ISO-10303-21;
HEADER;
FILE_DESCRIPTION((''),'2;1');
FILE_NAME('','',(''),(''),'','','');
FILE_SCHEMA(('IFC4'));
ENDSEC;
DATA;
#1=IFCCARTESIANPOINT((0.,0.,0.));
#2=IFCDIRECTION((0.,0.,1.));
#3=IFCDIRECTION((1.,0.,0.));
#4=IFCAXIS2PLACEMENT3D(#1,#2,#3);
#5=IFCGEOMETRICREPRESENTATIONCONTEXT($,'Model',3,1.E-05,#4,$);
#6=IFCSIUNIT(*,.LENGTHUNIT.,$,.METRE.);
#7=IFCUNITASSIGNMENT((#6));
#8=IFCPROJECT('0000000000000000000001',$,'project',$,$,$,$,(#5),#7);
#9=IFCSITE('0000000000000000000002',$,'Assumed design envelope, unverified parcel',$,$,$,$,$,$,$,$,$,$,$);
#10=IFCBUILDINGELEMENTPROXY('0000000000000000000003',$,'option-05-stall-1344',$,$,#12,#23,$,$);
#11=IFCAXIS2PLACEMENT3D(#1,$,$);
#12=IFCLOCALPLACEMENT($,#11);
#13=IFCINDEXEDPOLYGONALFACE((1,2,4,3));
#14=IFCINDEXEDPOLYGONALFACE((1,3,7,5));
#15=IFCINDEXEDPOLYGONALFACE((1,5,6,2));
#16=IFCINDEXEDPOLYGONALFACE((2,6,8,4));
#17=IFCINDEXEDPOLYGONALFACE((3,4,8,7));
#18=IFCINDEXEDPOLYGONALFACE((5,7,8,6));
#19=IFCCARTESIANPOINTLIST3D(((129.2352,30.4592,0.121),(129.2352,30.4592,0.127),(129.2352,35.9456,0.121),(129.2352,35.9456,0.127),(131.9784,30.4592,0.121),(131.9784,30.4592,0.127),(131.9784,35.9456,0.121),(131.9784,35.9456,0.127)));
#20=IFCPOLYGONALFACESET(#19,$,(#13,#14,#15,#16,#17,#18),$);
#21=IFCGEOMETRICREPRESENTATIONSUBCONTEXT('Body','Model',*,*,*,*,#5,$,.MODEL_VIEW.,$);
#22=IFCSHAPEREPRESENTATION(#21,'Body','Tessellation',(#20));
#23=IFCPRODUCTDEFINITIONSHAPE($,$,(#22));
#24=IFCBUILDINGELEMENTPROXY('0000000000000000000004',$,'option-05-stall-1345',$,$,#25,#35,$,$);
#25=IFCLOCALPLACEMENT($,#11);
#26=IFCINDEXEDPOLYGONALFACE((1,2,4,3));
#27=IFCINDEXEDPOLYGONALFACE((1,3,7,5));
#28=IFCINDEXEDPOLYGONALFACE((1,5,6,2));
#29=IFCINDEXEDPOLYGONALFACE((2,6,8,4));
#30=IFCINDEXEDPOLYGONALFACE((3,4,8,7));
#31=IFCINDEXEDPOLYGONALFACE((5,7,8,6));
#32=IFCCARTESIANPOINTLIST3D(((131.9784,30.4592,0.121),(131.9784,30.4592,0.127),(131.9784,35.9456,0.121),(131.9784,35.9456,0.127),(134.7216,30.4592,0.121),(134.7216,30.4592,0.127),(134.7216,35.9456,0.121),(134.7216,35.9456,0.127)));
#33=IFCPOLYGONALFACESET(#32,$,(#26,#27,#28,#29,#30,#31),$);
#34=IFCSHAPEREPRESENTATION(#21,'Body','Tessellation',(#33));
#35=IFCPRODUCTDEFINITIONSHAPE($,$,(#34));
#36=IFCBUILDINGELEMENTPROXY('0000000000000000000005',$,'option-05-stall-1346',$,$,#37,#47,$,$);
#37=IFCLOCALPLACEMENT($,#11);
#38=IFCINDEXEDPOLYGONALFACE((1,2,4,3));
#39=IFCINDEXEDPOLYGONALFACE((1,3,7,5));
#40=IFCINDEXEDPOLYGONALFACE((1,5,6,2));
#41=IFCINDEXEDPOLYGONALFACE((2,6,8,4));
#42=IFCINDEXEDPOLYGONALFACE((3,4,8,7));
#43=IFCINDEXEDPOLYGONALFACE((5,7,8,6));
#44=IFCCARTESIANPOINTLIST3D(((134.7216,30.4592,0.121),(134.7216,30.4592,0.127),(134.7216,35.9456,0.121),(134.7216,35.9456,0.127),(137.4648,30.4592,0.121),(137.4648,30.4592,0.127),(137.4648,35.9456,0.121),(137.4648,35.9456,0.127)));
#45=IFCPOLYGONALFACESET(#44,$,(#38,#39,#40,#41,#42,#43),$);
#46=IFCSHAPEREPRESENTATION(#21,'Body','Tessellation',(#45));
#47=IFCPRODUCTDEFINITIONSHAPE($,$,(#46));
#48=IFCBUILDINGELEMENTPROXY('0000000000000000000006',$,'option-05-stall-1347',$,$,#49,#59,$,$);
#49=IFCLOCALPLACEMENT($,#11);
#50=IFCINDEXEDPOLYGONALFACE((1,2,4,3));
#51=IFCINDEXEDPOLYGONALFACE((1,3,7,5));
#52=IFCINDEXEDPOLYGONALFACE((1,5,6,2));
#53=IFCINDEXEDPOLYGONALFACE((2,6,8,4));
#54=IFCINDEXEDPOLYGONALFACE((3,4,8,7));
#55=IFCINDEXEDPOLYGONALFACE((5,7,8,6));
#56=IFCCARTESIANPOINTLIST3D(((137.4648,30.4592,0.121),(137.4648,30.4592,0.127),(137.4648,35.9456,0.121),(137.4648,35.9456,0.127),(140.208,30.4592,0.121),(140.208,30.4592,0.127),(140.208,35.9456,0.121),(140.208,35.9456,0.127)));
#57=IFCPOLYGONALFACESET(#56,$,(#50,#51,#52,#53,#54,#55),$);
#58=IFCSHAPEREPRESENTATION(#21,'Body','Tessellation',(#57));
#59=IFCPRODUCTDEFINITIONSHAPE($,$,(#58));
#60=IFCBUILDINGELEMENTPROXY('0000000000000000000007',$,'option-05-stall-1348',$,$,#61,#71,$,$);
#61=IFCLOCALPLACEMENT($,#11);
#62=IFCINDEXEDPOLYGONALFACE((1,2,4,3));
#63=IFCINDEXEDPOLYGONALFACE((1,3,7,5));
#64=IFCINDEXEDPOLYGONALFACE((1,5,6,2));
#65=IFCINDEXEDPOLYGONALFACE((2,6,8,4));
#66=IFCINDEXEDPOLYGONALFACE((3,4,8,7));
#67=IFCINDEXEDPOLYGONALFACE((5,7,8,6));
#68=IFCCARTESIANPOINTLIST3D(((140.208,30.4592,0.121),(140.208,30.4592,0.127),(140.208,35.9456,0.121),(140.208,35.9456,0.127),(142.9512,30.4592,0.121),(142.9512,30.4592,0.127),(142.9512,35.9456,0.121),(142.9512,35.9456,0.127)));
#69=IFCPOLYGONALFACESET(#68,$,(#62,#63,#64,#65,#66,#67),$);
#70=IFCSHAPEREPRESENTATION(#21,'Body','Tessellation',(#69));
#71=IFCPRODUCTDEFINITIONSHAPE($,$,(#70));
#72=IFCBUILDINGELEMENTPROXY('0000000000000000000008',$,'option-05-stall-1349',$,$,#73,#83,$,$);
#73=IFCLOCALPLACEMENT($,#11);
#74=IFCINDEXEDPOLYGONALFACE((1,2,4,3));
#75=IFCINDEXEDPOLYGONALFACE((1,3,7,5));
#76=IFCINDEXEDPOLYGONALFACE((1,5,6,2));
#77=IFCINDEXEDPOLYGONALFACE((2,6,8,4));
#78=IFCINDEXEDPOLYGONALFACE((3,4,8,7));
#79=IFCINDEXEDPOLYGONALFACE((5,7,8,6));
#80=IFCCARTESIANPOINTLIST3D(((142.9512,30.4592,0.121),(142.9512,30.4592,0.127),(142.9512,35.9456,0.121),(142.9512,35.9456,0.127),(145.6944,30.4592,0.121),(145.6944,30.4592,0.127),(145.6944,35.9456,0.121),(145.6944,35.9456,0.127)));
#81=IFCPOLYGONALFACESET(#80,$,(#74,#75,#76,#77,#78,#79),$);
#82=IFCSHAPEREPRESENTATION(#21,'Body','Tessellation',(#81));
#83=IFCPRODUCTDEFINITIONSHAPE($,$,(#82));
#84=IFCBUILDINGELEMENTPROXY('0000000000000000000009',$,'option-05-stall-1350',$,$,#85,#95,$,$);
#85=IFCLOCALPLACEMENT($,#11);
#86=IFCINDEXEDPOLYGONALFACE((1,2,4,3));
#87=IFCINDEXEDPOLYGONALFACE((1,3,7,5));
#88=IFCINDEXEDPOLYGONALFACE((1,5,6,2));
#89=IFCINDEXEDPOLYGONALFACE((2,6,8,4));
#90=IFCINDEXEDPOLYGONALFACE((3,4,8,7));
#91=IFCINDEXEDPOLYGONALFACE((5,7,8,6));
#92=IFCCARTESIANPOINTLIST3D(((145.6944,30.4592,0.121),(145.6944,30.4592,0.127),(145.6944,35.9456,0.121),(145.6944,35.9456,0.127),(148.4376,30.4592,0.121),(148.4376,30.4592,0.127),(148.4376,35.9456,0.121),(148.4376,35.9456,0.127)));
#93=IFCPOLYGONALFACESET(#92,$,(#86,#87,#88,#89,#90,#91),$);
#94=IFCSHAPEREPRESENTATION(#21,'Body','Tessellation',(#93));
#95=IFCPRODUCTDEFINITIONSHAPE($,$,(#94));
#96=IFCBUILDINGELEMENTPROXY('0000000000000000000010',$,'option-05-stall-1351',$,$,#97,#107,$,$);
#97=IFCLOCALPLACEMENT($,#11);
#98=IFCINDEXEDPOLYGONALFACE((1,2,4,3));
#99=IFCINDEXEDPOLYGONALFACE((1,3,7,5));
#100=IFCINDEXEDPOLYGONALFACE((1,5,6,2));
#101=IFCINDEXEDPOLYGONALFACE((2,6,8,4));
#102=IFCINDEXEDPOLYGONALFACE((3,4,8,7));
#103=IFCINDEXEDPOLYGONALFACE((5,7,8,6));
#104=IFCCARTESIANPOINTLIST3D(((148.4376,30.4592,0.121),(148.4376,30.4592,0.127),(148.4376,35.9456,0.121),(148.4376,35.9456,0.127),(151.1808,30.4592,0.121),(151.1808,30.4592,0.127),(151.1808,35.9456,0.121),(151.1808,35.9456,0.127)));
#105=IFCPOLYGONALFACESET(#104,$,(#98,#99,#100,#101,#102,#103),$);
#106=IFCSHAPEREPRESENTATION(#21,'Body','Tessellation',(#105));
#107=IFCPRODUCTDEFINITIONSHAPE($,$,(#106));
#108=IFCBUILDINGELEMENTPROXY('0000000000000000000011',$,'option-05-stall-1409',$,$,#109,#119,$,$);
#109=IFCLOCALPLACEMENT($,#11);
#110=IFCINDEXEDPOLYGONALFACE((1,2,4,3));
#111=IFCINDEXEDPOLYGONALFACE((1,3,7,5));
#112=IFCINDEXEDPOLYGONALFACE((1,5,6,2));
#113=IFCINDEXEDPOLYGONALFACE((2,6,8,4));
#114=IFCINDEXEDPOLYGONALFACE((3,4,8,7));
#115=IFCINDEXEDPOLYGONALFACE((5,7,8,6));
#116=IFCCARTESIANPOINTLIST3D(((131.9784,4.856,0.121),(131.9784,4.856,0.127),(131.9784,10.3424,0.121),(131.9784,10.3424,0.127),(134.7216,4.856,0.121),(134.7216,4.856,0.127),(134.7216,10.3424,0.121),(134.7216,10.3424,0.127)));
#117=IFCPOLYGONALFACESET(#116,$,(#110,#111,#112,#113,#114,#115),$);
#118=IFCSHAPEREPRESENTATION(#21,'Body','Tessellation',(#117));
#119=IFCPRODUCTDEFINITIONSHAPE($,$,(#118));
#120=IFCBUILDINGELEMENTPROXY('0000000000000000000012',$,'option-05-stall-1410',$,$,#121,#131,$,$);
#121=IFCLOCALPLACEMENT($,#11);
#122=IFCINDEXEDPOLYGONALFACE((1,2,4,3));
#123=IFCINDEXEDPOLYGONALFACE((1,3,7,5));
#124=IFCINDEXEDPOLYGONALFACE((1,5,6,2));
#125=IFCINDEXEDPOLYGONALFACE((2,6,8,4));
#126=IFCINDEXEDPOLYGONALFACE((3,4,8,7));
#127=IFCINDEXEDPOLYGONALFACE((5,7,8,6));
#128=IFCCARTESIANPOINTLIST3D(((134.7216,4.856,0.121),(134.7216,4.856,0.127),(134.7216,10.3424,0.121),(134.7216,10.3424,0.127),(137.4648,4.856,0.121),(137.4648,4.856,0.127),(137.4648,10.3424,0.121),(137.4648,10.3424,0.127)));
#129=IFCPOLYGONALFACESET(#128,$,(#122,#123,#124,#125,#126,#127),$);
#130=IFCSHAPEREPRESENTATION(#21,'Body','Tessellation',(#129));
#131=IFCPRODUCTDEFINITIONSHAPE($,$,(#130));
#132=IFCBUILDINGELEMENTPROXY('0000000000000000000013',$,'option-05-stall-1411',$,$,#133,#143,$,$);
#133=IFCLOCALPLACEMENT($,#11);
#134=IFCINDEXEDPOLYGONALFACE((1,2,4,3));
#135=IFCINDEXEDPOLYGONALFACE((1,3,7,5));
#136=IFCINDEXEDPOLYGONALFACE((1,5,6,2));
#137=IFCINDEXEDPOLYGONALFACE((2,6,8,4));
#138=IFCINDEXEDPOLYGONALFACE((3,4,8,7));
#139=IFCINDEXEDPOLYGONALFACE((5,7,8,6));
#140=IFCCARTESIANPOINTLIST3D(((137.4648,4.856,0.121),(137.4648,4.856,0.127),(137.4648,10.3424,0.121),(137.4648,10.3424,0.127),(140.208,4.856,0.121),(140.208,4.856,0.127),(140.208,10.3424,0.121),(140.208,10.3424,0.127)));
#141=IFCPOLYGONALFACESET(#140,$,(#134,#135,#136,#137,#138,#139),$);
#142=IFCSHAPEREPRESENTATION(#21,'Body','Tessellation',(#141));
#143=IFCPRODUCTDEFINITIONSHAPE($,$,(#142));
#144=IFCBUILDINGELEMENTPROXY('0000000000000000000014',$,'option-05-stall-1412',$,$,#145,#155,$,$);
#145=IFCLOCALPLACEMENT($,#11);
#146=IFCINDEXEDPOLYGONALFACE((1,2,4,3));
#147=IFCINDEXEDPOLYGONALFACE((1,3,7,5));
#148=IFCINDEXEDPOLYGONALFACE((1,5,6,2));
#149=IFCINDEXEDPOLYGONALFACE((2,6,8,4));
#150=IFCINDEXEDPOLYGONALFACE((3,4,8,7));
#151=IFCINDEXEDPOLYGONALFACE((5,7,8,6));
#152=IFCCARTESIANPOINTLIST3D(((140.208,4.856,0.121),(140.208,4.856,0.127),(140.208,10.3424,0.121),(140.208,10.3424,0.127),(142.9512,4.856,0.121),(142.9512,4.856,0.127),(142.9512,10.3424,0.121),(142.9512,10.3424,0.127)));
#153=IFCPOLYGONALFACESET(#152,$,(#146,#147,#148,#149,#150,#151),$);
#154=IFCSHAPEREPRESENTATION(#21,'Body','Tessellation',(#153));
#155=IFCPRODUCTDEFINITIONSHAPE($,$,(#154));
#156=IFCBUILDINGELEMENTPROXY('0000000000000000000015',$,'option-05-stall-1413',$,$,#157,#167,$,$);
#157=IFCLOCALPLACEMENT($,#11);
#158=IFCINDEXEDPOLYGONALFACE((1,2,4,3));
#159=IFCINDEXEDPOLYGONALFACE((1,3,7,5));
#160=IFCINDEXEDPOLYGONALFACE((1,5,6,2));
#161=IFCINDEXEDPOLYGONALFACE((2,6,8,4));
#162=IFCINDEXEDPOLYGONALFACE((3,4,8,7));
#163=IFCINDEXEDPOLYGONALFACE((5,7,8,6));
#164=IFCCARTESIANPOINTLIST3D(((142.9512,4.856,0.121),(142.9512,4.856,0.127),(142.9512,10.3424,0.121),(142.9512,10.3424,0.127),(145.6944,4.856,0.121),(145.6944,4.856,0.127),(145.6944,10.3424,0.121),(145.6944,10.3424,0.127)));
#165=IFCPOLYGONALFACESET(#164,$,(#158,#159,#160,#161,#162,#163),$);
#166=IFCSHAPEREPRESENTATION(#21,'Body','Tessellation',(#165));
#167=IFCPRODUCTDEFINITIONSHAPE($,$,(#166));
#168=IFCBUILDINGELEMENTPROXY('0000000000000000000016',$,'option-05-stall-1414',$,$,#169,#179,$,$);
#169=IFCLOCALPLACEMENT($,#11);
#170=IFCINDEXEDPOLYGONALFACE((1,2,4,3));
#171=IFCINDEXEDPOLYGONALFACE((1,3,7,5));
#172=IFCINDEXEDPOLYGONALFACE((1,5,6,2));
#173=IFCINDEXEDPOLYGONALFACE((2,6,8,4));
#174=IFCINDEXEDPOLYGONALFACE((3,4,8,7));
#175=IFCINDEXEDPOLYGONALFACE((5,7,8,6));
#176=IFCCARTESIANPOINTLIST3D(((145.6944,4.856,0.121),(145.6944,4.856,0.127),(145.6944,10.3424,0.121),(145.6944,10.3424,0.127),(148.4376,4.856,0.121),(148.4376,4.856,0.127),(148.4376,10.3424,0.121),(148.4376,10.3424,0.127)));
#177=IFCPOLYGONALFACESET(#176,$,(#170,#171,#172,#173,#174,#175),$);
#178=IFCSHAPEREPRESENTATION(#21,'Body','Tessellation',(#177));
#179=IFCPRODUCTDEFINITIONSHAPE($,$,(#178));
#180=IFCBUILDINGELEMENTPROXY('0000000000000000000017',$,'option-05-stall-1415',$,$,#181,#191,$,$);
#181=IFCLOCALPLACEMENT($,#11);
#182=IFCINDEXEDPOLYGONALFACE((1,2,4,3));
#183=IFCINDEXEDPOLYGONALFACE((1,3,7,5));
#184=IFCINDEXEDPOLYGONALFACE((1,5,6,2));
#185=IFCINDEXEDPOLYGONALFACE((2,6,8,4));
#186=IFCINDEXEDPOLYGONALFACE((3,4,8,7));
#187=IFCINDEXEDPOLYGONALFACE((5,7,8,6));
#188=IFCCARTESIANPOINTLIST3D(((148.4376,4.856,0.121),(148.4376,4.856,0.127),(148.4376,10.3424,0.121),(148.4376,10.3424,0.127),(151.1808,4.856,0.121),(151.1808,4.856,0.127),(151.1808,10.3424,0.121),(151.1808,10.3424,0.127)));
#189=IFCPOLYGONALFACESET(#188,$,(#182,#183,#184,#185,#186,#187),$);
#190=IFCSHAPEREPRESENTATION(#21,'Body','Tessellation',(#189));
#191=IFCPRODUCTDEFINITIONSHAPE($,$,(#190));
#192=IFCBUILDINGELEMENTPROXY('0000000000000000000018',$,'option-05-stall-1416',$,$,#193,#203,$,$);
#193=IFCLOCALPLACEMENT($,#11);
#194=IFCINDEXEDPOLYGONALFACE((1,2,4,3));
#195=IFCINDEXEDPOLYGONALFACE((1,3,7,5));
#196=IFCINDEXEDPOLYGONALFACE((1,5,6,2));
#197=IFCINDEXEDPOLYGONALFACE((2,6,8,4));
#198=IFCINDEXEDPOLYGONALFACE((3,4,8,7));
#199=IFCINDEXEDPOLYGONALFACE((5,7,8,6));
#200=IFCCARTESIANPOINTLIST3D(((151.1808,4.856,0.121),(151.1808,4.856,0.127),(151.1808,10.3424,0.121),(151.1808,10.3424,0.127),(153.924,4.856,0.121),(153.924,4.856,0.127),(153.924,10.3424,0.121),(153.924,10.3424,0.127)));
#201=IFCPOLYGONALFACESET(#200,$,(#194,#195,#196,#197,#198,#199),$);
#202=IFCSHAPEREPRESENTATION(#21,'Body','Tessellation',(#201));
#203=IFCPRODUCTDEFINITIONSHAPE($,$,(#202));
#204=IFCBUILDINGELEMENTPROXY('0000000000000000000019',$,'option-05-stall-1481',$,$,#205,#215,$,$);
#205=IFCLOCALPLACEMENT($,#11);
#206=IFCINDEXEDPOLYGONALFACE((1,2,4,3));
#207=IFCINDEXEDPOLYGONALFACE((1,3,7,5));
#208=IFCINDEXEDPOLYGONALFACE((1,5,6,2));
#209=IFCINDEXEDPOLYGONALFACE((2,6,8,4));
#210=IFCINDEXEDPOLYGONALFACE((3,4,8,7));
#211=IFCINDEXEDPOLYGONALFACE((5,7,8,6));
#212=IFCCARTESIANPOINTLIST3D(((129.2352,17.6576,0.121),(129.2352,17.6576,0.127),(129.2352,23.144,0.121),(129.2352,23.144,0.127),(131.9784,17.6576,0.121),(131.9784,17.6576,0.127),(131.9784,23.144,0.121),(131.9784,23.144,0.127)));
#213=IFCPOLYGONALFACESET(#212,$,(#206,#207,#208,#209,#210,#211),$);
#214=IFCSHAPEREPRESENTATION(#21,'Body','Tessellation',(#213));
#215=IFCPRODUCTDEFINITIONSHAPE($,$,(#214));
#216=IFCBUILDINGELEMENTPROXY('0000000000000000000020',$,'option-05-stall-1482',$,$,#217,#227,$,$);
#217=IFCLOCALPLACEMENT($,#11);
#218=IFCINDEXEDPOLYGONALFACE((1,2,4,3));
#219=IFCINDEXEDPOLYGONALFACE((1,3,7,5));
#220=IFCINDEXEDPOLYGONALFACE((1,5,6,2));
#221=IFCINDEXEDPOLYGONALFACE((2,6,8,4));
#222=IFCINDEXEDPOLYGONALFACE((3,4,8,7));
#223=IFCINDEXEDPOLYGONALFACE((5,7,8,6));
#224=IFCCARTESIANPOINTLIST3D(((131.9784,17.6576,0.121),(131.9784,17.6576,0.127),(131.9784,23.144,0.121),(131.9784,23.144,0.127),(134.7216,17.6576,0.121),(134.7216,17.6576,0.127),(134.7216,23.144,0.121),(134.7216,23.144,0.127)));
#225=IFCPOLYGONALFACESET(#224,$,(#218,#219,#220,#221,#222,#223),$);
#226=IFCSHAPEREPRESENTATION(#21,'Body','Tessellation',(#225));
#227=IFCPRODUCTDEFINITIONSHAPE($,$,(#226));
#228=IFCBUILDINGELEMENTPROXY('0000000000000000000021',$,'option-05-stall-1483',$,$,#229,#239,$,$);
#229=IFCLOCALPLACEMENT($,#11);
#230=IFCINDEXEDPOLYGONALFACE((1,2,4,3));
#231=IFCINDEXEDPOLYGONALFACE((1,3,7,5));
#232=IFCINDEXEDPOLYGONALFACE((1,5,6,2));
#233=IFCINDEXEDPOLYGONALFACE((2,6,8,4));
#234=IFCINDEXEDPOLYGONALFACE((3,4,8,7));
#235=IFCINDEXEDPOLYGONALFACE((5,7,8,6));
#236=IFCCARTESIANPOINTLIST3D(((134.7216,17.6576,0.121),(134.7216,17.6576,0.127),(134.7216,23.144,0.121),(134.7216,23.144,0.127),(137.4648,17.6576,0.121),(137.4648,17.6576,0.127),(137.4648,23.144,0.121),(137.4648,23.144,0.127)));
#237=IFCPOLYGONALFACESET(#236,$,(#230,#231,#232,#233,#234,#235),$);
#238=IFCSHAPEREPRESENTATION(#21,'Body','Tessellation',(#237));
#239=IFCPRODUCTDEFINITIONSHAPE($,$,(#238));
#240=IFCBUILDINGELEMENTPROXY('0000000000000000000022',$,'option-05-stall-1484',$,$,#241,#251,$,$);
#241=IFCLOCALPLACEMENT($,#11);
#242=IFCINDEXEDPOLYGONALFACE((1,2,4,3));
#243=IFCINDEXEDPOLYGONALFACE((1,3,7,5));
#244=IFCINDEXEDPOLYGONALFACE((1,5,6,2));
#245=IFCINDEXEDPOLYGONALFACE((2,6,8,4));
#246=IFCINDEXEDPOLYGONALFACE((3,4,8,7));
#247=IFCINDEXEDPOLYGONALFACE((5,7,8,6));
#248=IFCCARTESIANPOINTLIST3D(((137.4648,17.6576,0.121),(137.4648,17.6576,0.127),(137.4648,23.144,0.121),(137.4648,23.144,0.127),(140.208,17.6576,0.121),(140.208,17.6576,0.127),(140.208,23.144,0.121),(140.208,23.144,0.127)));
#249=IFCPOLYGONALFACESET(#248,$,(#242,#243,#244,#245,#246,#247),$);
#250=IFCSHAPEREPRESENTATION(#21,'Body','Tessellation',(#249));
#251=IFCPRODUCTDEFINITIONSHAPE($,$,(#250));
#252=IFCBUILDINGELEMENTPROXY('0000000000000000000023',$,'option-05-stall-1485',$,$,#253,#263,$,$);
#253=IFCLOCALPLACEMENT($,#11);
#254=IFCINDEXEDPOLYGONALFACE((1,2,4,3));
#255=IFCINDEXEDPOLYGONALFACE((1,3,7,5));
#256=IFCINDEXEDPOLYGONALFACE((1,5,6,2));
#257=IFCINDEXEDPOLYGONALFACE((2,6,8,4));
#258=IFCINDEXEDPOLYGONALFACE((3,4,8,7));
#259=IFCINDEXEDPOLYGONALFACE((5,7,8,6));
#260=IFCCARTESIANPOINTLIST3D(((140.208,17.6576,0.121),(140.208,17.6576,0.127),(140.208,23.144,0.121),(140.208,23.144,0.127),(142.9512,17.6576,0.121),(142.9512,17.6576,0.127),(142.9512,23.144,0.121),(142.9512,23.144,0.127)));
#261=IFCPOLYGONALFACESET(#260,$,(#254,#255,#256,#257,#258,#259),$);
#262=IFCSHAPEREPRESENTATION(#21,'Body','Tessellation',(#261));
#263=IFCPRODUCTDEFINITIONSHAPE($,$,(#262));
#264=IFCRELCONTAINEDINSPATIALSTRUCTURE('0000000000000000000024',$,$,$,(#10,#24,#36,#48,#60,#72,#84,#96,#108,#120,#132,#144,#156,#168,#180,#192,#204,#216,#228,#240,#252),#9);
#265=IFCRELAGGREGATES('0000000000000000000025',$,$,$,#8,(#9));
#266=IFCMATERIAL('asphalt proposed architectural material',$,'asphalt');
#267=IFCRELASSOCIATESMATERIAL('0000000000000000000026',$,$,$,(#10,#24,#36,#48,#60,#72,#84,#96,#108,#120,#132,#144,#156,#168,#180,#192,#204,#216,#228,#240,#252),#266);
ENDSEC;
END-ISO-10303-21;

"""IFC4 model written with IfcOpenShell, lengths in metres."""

from ifc_helpers import new_model, si_unit, frame, origin_with_axes, place, context, subcontext, project, spatial, rectangle, extrude, material, element, save


model = new_model("IFC4")

# Units and contexts
model_context = context("Model", 3, precision=1e-05, world=origin_with_axes())
body_context = subcontext(model_context, "Body", "Model", "MODEL_VIEW")
ifc_project = project(units=[si_unit("LENGTHUNIT", "METRE")], contexts=[model_context])

# Site
site = spatial("IfcSite", under=ifc_project, Name="Assumed design envelope, unverified parcel")

# Building element proxies
ifc_material = material(Name="asphalt proposed architectural material", Category="asphalt")
for number, where, z_axis, x_axis, name in (
    (1, (130.6068, 33.2024, 0.121), (0.0, 0.0, 1.0), (1.0, 0.0, 0.0), "option-05-stall-1344"),
    (2, (133.35, 33.2024, 0.121), (0.0, 0.0, 1.0), (1.0, 0.0, 0.0), "option-05-stall-1345"),
    (3, (136.0932, 33.2024, 0.121), (0.0, 0.0, 1.0), (1.0, 0.0, 0.0), "option-05-stall-1346"),
    (4, (138.8364, 33.2024, 0.121), (0.0, 0.0, 1.0), (1.0, 0.0, 0.0), "option-05-stall-1347"),
    (5, (141.5796, 33.2024, 0.121), (0.0, 0.0, 1.0), (1.0, 0.0, 0.0), "option-05-stall-1348"),
    (6, (144.3228, 33.2024, 0.121), (0.0, 0.0, 1.0), (1.0, 0.0, 0.0), "option-05-stall-1349"),
    (7, (147.066, 33.2024, 0.121), (0.0, 0.0, 1.0), (1.0, 0.0, 0.0), "option-05-stall-1350"),
    (8, (149.8092, 33.2024, 0.121), (0.0, 0.0, 1.0), (1.0, 0.0, 0.0), "option-05-stall-1351"),
):
    element("IfcBuildingElementProxy", number, at=place(None, frame(where, z_axis=z_axis, x_axis=x_axis)), inside=site, material=ifc_material, Name=name, context=body_context, shape_type="SweptSolid", body=[
        extrude(rectangle(XDim=2.7432, YDim=5.4864), origin_with_axes(), (0.0, 0.0, 1.0), 0.006),
    ])
for number, where, z_axis, x_axis, name in (
    (9, (133.35, 7.5992, 0.121), (0.0, 0.0, 1.0), (1.0, 0.0, 0.0), "option-05-stall-1409"),
    (10, (136.0932, 7.5992, 0.121), (0.0, 0.0, 1.0), (1.0, 0.0, 0.0), "option-05-stall-1410"),
    (11, (138.8364, 7.5992, 0.121), (0.0, 0.0, 1.0), (1.0, 0.0, 0.0), "option-05-stall-1411"),
    (12, (141.5796, 7.5992, 0.121), (0.0, 0.0, 1.0), (1.0, 0.0, 0.0), "option-05-stall-1412"),
    (13, (144.3228, 7.5992, 0.121), (0.0, 0.0, 1.0), (1.0, 0.0, 0.0), "option-05-stall-1413"),
    (14, (147.066, 7.5992, 0.121), (0.0, 0.0, 1.0), (1.0, 0.0, 0.0), "option-05-stall-1414"),
    (15, (149.8092, 7.5992, 0.121), (0.0, 0.0, 1.0), (1.0, 0.0, 0.0), "option-05-stall-1415"),
    (16, (152.5524, 7.5992, 0.121), (0.0, 0.0, 1.0), (1.0, 0.0, 0.0), "option-05-stall-1416"),
):
    element("IfcBuildingElementProxy", number, at=place(None, frame(where, z_axis=z_axis, x_axis=x_axis)), inside=site, material=ifc_material, Name=name, context=body_context, shape_type="SweptSolid", body=[
        extrude(rectangle(XDim=2.7432, YDim=5.4864), origin_with_axes(), (0.0, 0.0, 1.0), 0.006),
    ])
for number, where, z_axis, x_axis, name in (
    (17, (130.6068, 20.4008, 0.121), (0.0, 0.0, 1.0), (1.0, 0.0, 0.0), "option-05-stall-1481"),
    (18, (133.35, 20.4008, 0.121), (0.0, 0.0, 1.0), (1.0, 0.0, 0.0), "option-05-stall-1482"),
    (19, (136.0932, 20.4008, 0.121), (0.0, 0.0, 1.0), (1.0, 0.0, 0.0), "option-05-stall-1483"),
    (20, (138.8364, 20.4008, 0.121), (0.0, 0.0, 1.0), (1.0, 0.0, 0.0), "option-05-stall-1484"),
    (21, (141.5796, 20.4008, 0.121), (0.0, 0.0, 1.0), (1.0, 0.0, 0.0), "option-05-stall-1485"),
):
    element("IfcBuildingElementProxy", number, at=place(None, frame(where, z_axis=z_axis, x_axis=x_axis)), inside=site, material=ifc_material, Name=name, context=body_context, shape_type="SweptSolid", body=[
        extrude(rectangle(XDim=2.7432, YDim=5.4864), origin_with_axes(), (0.0, 0.0, 1.0), 0.006),
    ])

save(model, "model.ifc")
